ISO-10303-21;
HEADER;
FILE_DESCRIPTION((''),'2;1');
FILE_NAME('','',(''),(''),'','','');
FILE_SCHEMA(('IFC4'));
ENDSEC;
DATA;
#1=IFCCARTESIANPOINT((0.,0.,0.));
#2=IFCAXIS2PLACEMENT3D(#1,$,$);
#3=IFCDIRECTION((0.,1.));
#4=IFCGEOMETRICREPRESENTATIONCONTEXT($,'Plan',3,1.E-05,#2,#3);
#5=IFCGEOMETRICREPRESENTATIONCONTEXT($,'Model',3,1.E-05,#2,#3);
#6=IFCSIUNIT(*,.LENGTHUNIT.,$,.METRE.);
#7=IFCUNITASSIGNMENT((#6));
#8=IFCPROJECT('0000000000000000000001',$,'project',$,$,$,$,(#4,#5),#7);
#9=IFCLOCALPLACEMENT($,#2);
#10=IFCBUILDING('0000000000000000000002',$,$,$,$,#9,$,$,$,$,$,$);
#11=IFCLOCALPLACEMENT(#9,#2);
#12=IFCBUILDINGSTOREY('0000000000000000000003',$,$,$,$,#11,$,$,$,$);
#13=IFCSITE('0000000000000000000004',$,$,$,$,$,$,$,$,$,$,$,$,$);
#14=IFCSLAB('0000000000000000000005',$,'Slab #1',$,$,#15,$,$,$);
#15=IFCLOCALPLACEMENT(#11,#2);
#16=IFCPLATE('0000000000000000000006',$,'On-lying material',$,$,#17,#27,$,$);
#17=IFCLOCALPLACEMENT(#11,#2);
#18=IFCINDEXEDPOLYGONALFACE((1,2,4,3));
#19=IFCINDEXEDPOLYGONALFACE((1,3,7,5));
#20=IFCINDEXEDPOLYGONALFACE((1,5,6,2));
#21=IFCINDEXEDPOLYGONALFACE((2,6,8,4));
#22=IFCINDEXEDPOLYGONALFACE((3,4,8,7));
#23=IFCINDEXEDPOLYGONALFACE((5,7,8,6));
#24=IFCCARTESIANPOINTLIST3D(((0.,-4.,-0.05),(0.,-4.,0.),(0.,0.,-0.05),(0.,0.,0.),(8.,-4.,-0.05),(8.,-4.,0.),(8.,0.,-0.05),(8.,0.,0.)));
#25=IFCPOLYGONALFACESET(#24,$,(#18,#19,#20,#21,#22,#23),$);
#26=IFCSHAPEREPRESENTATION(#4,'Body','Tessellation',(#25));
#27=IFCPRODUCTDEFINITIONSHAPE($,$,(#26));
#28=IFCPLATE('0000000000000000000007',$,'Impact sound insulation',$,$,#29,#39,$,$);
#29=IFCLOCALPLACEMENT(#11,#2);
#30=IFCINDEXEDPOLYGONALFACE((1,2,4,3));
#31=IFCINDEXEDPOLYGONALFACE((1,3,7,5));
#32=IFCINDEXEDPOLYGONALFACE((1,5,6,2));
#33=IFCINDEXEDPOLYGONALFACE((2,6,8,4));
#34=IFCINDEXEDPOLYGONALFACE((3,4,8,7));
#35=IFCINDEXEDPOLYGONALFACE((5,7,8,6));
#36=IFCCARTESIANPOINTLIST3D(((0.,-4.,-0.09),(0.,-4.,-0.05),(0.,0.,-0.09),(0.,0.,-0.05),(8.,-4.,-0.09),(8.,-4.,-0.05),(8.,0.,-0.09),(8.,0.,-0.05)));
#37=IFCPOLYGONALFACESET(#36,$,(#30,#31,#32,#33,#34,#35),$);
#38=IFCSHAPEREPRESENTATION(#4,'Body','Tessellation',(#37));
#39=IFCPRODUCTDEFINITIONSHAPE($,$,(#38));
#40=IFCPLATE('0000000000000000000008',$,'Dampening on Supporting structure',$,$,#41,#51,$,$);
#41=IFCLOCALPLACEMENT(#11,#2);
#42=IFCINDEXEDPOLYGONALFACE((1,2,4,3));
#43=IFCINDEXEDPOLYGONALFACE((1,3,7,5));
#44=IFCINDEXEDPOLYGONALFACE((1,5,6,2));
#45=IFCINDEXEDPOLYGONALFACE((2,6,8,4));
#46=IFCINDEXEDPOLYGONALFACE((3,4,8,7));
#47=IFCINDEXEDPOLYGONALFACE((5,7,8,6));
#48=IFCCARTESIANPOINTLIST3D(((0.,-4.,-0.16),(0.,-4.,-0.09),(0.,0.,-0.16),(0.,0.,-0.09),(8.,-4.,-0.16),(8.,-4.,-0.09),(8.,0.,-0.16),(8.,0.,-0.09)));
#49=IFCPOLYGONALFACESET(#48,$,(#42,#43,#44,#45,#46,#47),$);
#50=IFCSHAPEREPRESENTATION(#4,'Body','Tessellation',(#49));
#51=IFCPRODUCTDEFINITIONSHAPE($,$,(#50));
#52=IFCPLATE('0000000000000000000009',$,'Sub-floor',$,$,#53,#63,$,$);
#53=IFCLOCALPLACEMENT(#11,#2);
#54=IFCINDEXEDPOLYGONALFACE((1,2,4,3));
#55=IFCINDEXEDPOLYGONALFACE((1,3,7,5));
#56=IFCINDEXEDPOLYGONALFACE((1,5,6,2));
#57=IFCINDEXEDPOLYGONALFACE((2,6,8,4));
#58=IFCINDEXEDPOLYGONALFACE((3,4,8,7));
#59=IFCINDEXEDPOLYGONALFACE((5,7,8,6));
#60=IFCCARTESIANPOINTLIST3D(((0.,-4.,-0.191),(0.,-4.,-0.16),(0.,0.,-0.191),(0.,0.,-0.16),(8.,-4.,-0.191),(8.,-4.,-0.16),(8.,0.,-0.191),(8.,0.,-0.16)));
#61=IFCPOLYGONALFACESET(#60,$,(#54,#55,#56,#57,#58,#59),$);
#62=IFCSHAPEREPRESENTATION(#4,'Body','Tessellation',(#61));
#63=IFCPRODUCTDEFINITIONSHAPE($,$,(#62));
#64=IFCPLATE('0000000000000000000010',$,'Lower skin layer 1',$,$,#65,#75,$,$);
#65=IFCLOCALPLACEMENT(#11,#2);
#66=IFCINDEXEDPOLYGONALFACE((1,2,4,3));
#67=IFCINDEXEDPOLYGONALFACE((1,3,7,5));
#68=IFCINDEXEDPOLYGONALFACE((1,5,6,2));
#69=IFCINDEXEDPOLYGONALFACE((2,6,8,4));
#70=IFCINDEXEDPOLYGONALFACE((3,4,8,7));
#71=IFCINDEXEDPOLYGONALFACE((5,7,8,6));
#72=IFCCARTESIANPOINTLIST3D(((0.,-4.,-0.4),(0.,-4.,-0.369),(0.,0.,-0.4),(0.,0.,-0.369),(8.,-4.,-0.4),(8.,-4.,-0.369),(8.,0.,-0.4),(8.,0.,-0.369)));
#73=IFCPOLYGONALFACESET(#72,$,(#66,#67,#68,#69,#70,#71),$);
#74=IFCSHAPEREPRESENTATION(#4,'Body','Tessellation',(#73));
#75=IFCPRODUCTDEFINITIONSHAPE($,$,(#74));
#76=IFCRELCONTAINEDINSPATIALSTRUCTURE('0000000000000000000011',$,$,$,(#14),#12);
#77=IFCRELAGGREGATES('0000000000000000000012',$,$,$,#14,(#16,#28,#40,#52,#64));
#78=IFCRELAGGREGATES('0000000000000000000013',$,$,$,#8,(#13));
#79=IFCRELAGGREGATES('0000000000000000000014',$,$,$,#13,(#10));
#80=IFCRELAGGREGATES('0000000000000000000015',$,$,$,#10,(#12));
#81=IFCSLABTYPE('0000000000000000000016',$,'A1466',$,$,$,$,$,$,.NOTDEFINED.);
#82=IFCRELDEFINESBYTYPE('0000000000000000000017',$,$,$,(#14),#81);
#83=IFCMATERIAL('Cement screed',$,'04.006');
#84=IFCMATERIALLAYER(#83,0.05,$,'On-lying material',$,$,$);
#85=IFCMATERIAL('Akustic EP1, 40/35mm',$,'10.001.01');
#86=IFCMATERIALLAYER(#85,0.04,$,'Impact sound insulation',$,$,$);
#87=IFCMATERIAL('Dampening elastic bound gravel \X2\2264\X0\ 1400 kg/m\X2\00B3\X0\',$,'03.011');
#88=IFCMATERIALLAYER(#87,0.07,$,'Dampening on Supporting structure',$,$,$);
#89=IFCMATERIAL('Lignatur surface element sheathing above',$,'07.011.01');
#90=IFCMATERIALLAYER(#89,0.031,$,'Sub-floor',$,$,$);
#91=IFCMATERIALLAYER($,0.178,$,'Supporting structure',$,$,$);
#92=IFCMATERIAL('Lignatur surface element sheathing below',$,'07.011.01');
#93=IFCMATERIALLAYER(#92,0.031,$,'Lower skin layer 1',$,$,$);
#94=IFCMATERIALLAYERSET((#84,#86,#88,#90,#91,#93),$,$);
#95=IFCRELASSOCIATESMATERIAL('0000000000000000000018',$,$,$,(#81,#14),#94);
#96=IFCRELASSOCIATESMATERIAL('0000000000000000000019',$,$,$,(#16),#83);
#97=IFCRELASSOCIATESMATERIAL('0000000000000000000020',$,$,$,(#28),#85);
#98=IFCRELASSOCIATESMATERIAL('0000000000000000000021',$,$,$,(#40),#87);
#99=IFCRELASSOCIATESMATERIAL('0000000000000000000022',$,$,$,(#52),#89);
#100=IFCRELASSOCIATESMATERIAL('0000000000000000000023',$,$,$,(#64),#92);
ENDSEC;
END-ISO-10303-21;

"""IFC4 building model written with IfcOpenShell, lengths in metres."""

from ifc_helpers import new_model, si_unit, direction, frame, frame_2d, origin, origin_with_axes, place, context, project, spatial, rectangle, extrude, material, layer, layer_set, type_object, element, aggregate, save


model = new_model("IFC4")

# Units and contexts
plan_context = context("Plan", 3, precision=1e-05, world=origin(), true_north=direction((0.0, 1.0)))
model_context = context("Model", 3, precision=1e-05, world=origin(), true_north=direction((0.0, 1.0)))
ifc_project = project(units=[si_unit("LENGTHUNIT", "METRE")], contexts=[plan_context, model_context])

# Site, building, storey
site = spatial("IfcSite", under=ifc_project)
building_placement = place(None, origin())
building = spatial("IfcBuilding", under=site, at=building_placement)
storey_placement = place(building_placement, origin())
storey = spatial("IfcBuildingStorey", under=building, at=storey_placement)

# Slab, plates
ifc_material_1 = material(Name="Cement screed", Category="04.006")
ifc_layer_1 = layer(ifc_material_1, 0.05, Name="On-lying material")
ifc_material_2 = material(Name="Akustic EP1, 40/35mm", Category="10.001.01")
ifc_layer_2 = layer(ifc_material_2, 0.04, Name="Impact sound insulation")
ifc_material_3 = material(Name="Dampening elastic bound gravel ≤ 1400 kg/m³", Category="03.011")
ifc_layer_3 = layer(ifc_material_3, 0.07, Name="Dampening on Supporting structure")
ifc_material_4 = material(Name="Lignatur surface element sheathing above", Category="07.011.01")
ifc_layer_4 = layer(ifc_material_4, 0.031, Name="Sub-floor")
ifc_layer_5 = layer(None, 0.178, Name="Supporting structure")
ifc_material_5 = material(Name="Lignatur surface element sheathing below", Category="07.011.01")
ifc_layer_6 = layer(ifc_material_5, 0.031, Name="Lower skin layer 1")
ifc_layer_set = layer_set([ifc_layer_1, ifc_layer_2, ifc_layer_3, ifc_layer_4, ifc_layer_5, ifc_layer_6])
slab_type = type_object("IfcSlabType", Name="A1466", PredefinedType="NOTDEFINED", material=ifc_layer_set)
slab_placement = place(None, frame((0.0, 0.0, 0.0), z_axis=(0.0, 0.0, -1.0), x_axis=(1.0, 0.0, 0.0)))
slab = element("IfcSlab", 1, at=slab_placement, inside=storey, type_object=slab_type, material=ifc_layer_set, Name="Slab #1")
plate_1_placement = place(slab_placement, origin())
plate_1 = element("IfcPlate", 2, at=plate_1_placement, material=ifc_material_1, Name="On-lying material", context=plan_context, shape_type="SweptSolid", body=[
    extrude(rectangle(XDim=8.0, YDim=4.0, at=frame_2d((4.0, 2.0), x_axis=(1.0, 0.0))), origin_with_axes(), (0.0, 0.0, 1.0), 0.05),
])
plate_2_placement = place(slab_placement, origin())
plate_2 = element("IfcPlate", 3, at=plate_2_placement, material=ifc_material_2, Name="Impact sound insulation", context=plan_context, shape_type="SweptSolid", body=[
    extrude(rectangle(XDim=8.0, YDim=4.0, at=frame_2d((4.0, 2.0), x_axis=(1.0, 0.0))), frame((0.0, 0.0, 0.05), z_axis=(0.0, 0.0, 1.0), x_axis=(1.0, 0.0, 0.0)), (0.0, 0.0, 1.0), 0.04),
])
plate_3_placement = place(slab_placement, origin())
plate_3 = element("IfcPlate", 4, at=plate_3_placement, material=ifc_material_3, Name="Dampening on Supporting structure", context=plan_context, shape_type="SweptSolid", body=[
    extrude(rectangle(XDim=8.0, YDim=4.0, at=frame_2d((4.0, 2.0), x_axis=(1.0, 0.0))), frame((0.0, 0.0, 0.09), z_axis=(0.0, 0.0, 1.0), x_axis=(1.0, 0.0, 0.0)), (0.0, 0.0, 1.0), 0.07),
])
plate_4_placement = place(slab_placement, origin())
plate_4 = element("IfcPlate", 5, at=plate_4_placement, material=ifc_material_4, Name="Sub-floor", context=plan_context, shape_type="SweptSolid", body=[
    extrude(rectangle(XDim=8.0, YDim=4.0, at=frame_2d((4.0, 2.0), x_axis=(1.0, 0.0))), frame((0.0, 0.0, 0.16), z_axis=(0.0, 0.0, 1.0), x_axis=(1.0, 0.0, 0.0)), (0.0, 0.0, 1.0), 0.031),
])
plate_5_placement = place(slab_placement, origin())
plate_5 = element("IfcPlate", 6, at=plate_5_placement, material=ifc_material_5, Name="Lower skin layer 1", context=plan_context, shape_type="SweptSolid", body=[
    extrude(rectangle(XDim=8.0, YDim=4.0, at=frame_2d((4.0, 2.0), x_axis=(1.0, 0.0))), frame((0.0, 0.0, 0.369), z_axis=(0.0, 0.0, 1.0), x_axis=(1.0, 0.0, 0.0)), (0.0, 0.0, 1.0), 0.031),
])
aggregate(slab, [plate_1, plate_2, plate_3, plate_4, plate_5])

save(model, "model.ifc")
